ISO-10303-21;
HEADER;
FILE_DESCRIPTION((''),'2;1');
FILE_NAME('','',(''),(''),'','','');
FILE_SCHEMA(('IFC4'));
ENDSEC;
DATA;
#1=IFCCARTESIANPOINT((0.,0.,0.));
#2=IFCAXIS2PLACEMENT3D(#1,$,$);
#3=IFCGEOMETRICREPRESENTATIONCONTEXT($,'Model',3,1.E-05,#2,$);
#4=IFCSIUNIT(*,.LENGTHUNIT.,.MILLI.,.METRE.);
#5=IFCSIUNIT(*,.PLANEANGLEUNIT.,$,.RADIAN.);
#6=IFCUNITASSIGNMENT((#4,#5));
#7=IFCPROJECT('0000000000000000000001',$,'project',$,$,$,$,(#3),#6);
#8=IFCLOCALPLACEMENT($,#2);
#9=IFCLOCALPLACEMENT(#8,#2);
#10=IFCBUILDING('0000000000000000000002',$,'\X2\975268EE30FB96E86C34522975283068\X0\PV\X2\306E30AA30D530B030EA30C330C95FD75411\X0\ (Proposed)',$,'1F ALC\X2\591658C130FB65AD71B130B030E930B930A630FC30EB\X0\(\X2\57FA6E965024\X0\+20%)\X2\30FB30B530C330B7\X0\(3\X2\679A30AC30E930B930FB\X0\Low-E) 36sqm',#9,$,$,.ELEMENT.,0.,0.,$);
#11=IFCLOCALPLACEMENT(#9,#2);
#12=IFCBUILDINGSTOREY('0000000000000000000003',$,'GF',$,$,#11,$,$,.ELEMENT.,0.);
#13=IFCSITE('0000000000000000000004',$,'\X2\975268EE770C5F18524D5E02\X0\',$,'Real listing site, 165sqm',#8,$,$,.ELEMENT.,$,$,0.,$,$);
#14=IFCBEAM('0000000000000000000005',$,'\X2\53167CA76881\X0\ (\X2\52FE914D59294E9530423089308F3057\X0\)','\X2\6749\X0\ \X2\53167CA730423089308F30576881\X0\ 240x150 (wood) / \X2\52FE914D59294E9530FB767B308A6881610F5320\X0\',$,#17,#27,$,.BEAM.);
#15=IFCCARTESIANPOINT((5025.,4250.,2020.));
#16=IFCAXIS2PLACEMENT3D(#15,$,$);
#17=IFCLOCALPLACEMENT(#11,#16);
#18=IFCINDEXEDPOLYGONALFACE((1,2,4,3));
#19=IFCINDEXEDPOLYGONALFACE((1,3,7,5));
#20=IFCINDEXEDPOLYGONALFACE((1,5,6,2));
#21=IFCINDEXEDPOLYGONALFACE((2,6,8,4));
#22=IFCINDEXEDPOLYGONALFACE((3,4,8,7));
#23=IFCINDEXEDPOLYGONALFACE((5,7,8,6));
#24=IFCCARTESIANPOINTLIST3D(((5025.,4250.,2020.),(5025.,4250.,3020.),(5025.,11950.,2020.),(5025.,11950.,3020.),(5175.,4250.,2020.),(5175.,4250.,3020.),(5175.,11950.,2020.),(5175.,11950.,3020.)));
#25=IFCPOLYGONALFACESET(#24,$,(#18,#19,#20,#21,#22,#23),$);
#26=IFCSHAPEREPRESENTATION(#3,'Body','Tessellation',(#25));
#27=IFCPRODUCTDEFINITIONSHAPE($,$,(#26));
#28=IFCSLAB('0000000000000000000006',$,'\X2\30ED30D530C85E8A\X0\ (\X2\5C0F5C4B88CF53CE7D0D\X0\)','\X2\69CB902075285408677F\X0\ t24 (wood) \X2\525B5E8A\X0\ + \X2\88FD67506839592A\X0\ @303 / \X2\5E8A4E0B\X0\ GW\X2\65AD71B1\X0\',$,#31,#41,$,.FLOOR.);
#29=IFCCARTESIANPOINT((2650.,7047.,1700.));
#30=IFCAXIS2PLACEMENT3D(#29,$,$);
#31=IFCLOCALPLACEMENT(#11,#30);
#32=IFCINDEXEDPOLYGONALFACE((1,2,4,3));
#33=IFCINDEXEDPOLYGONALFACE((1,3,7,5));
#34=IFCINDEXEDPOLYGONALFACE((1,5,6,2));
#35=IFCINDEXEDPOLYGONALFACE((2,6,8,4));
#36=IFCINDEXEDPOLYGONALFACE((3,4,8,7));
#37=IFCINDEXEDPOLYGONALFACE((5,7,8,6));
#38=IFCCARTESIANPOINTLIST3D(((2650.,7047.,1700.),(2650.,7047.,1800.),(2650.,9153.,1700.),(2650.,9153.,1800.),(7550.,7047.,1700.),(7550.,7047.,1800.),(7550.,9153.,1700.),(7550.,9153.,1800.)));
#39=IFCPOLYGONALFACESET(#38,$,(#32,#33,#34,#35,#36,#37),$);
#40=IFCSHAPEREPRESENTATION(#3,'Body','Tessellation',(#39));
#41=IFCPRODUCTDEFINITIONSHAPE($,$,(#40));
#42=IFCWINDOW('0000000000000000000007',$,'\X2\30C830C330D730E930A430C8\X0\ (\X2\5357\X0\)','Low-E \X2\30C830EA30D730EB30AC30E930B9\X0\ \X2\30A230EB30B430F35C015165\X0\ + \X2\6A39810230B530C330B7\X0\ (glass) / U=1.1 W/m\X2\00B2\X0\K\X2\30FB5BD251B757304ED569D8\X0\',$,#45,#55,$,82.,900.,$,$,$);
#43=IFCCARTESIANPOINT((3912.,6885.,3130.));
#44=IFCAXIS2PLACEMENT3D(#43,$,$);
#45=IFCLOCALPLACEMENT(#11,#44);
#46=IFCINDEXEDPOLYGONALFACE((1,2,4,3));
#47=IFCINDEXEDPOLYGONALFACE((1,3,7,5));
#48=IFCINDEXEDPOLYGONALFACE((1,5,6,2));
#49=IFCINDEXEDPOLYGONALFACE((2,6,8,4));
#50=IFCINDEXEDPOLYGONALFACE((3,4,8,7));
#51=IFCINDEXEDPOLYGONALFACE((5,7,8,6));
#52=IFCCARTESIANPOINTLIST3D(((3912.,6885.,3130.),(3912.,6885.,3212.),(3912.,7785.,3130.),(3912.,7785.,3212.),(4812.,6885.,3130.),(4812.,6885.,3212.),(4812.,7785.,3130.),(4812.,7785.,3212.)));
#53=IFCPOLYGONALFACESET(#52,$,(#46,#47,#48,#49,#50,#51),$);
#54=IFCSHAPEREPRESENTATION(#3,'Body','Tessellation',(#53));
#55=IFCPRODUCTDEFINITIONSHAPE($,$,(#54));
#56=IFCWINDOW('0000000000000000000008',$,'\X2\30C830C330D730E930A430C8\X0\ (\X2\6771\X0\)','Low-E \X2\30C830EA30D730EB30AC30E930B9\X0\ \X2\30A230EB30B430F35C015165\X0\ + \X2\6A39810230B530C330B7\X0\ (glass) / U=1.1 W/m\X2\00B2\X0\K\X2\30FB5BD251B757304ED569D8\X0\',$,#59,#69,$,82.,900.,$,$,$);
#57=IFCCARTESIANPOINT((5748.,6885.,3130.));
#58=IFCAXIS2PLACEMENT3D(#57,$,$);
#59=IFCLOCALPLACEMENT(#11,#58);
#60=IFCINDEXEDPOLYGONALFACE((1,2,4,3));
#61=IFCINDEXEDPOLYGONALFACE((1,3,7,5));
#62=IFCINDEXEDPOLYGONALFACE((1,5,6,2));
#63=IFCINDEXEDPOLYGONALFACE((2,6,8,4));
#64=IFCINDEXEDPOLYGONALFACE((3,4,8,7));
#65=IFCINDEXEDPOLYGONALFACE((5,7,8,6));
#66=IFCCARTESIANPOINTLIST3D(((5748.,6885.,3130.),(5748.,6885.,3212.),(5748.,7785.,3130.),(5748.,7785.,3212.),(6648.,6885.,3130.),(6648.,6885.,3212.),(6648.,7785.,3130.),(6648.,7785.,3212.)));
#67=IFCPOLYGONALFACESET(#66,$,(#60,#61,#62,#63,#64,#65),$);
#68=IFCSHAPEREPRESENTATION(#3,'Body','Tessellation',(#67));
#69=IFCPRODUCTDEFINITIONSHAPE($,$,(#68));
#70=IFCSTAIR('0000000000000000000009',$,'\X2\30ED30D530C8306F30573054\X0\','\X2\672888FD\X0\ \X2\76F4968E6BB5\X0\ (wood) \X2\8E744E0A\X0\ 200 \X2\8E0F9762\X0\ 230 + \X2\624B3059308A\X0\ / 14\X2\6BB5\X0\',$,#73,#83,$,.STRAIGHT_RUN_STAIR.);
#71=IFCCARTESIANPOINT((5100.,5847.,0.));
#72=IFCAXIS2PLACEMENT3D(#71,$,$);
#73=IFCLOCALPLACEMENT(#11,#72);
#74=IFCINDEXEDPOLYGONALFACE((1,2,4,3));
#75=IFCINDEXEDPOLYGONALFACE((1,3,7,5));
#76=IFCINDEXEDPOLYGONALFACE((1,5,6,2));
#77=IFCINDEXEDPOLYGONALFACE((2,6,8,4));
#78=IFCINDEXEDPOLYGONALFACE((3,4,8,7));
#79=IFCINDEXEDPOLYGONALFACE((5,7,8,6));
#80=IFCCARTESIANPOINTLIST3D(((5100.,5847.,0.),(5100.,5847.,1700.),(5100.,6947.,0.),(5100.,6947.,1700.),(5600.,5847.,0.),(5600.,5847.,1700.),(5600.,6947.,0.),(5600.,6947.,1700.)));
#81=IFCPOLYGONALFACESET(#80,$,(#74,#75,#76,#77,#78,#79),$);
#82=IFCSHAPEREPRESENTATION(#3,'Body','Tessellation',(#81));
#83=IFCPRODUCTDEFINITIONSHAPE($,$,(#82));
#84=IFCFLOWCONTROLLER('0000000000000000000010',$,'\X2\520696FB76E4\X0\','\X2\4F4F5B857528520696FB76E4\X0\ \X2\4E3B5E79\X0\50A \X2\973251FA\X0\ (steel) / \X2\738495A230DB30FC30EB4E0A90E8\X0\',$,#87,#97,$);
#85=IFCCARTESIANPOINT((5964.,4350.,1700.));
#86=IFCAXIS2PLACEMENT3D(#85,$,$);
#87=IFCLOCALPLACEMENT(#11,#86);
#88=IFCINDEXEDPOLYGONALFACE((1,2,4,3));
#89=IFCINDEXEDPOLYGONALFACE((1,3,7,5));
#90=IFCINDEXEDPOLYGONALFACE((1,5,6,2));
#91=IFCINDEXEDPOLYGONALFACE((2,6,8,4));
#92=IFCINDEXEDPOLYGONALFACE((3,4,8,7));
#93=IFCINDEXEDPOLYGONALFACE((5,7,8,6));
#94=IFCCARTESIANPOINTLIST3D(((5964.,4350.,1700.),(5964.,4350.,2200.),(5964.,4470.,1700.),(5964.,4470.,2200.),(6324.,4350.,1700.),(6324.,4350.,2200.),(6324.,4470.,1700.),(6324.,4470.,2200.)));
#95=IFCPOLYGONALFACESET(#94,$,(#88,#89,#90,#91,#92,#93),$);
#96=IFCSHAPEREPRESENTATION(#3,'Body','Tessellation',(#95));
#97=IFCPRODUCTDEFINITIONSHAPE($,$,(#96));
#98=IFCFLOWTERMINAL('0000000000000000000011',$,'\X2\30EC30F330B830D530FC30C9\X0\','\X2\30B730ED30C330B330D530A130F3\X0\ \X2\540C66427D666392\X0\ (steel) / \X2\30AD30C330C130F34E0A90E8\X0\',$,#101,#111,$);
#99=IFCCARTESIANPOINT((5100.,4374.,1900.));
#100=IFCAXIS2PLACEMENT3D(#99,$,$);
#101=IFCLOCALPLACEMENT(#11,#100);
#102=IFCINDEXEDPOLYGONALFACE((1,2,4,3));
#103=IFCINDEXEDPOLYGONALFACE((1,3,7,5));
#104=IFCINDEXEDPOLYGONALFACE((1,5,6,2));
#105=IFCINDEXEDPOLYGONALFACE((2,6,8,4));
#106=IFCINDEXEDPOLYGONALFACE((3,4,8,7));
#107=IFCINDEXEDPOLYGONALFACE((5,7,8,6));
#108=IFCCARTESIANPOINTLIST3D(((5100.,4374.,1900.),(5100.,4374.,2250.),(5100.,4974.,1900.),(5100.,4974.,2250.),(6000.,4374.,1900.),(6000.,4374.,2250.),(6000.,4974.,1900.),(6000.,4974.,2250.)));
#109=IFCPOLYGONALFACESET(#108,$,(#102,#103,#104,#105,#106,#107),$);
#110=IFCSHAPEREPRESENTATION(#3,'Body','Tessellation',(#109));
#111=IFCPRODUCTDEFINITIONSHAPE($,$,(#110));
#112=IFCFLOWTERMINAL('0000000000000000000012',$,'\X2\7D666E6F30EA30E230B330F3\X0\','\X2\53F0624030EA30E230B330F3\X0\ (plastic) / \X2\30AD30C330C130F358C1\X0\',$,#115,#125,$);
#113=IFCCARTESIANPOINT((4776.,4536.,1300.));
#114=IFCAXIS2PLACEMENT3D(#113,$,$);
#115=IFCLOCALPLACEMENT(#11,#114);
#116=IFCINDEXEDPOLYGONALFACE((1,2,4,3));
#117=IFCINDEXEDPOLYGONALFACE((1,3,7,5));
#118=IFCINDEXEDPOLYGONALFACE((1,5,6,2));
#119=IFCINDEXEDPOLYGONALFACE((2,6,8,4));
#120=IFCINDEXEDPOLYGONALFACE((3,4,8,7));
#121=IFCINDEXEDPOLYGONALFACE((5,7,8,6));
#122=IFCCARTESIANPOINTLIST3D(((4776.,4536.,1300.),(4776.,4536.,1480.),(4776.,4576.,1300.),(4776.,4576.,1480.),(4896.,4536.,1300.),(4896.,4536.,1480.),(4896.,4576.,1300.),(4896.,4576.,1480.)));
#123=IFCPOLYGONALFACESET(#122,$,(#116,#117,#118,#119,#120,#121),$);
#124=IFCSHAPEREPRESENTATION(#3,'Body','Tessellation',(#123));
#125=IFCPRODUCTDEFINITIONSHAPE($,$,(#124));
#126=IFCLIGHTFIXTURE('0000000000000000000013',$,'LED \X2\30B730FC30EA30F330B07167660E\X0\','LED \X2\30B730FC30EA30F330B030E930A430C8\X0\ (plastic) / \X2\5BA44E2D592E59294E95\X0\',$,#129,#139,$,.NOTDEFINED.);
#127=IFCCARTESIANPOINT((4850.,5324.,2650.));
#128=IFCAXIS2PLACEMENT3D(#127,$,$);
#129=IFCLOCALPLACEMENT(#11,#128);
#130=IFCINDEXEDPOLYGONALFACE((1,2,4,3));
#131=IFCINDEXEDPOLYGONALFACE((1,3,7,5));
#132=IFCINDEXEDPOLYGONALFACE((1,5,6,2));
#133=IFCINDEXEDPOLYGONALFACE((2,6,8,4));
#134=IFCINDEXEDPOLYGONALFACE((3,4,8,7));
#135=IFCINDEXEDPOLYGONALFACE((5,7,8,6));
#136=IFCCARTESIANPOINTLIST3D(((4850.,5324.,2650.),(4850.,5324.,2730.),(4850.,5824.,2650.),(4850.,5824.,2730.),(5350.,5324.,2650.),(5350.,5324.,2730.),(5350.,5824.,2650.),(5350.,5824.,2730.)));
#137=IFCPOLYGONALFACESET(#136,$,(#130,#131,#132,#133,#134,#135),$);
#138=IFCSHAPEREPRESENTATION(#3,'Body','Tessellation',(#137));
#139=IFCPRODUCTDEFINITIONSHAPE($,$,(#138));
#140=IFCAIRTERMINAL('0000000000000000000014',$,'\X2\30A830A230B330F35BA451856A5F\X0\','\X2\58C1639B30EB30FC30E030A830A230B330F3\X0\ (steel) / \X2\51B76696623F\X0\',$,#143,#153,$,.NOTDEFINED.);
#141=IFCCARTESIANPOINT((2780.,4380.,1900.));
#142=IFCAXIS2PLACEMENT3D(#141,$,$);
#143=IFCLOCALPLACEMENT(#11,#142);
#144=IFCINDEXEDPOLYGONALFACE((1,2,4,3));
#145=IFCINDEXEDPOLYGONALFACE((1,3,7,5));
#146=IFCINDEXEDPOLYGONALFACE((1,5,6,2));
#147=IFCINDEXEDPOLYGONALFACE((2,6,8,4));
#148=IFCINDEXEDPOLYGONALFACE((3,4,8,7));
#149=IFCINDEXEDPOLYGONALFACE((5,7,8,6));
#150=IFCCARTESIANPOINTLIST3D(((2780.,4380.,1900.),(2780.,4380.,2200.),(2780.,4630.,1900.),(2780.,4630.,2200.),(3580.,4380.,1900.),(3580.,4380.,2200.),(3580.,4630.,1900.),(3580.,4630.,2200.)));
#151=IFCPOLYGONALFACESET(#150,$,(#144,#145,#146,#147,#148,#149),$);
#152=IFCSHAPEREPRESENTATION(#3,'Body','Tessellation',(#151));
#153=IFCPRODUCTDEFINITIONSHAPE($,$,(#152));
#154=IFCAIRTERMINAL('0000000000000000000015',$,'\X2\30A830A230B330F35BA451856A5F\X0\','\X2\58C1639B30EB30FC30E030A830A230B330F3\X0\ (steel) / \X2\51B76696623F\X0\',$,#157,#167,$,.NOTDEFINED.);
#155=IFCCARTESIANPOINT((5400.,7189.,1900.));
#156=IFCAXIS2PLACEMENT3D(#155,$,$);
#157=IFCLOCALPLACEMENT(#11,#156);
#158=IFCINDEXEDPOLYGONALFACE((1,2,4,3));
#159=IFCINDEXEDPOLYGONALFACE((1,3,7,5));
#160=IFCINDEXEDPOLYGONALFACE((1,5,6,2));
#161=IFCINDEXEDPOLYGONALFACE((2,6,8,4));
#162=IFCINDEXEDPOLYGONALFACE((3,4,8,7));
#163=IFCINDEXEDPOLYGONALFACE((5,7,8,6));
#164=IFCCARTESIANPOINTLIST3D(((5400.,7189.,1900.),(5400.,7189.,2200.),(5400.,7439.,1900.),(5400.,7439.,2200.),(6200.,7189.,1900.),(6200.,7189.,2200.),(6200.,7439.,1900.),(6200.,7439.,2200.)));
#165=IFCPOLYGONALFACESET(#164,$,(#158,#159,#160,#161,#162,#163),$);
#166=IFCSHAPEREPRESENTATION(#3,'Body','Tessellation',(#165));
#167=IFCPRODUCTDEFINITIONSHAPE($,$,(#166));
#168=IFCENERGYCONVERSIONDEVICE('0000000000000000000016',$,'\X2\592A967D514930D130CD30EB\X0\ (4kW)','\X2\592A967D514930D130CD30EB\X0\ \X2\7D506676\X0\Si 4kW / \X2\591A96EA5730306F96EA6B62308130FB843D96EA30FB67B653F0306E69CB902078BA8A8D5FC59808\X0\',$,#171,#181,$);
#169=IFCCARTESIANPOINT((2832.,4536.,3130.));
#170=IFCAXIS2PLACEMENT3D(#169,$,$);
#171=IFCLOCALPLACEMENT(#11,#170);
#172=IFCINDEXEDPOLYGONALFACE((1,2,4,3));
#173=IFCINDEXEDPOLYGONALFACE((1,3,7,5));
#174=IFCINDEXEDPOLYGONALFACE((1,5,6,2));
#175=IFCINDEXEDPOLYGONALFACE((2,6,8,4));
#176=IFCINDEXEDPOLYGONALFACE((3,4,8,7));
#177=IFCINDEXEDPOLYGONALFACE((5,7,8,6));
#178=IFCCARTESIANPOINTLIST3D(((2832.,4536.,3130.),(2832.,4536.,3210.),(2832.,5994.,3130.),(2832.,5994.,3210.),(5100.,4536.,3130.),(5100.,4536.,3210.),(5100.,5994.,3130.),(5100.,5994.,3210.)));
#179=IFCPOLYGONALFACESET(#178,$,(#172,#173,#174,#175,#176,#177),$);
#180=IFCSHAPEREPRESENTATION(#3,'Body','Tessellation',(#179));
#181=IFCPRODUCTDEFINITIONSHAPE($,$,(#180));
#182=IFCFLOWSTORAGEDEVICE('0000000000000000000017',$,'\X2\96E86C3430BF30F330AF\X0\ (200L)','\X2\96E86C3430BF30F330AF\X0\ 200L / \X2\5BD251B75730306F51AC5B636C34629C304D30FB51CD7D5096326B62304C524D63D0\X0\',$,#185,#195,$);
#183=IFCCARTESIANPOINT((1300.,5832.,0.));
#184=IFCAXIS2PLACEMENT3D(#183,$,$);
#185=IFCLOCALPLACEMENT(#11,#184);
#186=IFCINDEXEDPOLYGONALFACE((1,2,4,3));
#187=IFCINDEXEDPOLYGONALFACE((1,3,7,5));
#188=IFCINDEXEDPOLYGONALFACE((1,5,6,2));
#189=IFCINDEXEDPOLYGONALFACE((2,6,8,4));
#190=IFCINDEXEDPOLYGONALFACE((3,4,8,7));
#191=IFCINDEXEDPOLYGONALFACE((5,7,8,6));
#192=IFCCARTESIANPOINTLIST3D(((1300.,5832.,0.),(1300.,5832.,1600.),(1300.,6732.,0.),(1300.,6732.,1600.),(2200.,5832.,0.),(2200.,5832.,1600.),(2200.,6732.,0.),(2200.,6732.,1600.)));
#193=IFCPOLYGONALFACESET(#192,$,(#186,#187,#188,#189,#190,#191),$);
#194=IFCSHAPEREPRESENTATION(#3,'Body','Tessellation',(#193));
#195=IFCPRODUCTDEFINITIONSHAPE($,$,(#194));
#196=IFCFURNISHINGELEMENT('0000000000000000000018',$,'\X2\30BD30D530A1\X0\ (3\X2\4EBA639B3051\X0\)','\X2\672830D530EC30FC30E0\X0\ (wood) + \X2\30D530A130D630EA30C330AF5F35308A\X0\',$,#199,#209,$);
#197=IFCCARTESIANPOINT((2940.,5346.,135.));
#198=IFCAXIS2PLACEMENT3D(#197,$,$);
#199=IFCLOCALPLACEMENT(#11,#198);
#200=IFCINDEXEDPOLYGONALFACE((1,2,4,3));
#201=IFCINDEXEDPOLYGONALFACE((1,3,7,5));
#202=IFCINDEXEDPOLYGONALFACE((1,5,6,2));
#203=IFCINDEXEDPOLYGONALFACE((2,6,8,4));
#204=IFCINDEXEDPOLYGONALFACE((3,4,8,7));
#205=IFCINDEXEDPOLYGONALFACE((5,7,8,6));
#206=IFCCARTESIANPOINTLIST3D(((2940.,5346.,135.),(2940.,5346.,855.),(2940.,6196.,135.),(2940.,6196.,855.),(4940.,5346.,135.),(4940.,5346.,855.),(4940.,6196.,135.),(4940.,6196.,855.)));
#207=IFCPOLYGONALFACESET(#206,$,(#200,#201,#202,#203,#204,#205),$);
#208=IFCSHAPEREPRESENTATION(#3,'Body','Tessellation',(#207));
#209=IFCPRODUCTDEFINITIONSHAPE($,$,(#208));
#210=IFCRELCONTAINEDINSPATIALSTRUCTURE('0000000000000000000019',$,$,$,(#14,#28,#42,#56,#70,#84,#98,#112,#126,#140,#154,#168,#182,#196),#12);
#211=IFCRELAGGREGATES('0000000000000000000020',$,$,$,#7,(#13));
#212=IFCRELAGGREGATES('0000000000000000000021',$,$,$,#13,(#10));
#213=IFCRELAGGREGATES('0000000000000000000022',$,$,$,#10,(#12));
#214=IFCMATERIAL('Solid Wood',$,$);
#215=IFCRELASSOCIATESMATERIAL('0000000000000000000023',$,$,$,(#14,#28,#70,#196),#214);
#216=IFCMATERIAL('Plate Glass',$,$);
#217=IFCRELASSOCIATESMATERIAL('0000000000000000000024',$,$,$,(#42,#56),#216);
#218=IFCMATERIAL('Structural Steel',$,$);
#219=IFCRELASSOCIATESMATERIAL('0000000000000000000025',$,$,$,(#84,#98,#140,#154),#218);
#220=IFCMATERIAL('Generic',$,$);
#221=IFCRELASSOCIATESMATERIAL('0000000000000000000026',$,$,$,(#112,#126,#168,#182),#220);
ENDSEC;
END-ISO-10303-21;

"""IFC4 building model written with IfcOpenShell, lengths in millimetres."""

from ifc_helpers import new_model, si_unit, frame, frame_2d, origin, place, context, project, spatial, rectangle, extrude, material, element, save


model = new_model("IFC4")

# Units and contexts
model_context = context("Model", 3, precision=1e-05, world=origin())
ifc_project = project(units=[si_unit("LENGTHUNIT", "METRE", prefix="MILLI"), si_unit("PLANEANGLEUNIT", "RADIAN")], contexts=[model_context])

# Site, building, storey
site_placement = place(None, origin())
site = spatial("IfcSite", under=ifc_project, at=site_placement, Name="青森県弘前市", ObjectType="Real listing site, 165sqm", CompositionType="ELEMENT", RefElevation=0.0)
building_placement = place(site_placement, origin())
building = spatial("IfcBuilding", under=site, at=building_placement, Name="青森・雨水利用とPVのオフグリッド志向 (Proposed)", ObjectType="1F ALC外壁・断熱グラスウール(基準値+20%)・サッシ(3枚ガラス・Low-E) 36sqm", CompositionType="ELEMENT", ElevationOfRefHeight=0.0, ElevationOfTerrain=0.0)
storey_placement = place(building_placement, origin())
storey = spatial("IfcBuildingStorey", under=building, at=storey_placement, Name="GF", CompositionType="ELEMENT", Elevation=0.0)

# Shared definitions
ifc_material_1 = material(Name="Solid Wood")

# Beam
beam_placement = place(storey_placement, frame((5025.0, 4250.0, 2020.0)))
element("IfcBeam", 1, at=beam_placement, inside=storey, material=ifc_material_1, Name="化粧梁 (勾配天井あらわし)", Description="杉 化粧あらわし梁 240x150 (wood) / 勾配天井・登り梁意匠", PredefinedType="BEAM", context=model_context, shape_type="SweptSolid", body=[
    extrude(rectangle(XDim=150.0, YDim=7700.0, at=frame_2d((75.0, 3850.0))), frame((5025.0, 4250.0, 2020.0)), (0.0, 0.0, 1.0), 1000.0),
])

# Slab
slab_placement = place(storey_placement, frame((2650.0, 7047.0, 1700.0)))
element("IfcSlab", 2, at=slab_placement, inside=storey, material=ifc_material_1, Name="ロフト床 (小屋裏収納)", Description="構造用合板 t24 (wood) 剛床 + 製材根太 @303 / 床下 GW断熱", PredefinedType="FLOOR", context=model_context, shape_type="SweptSolid", body=[
    extrude(rectangle(XDim=4900.0, YDim=2106.0, at=frame_2d((2450.0, 1053.0))), frame((2650.0, 7047.0, 1700.0)), (0.0, 0.0, 1.0), 100.0),
])

# Windows
ifc_material_2 = material(Name="Plate Glass")
window_1_placement = place(storey_placement, frame((3912.0, 6885.0, 3130.0)))
element("IfcWindow", 3, at=window_1_placement, inside=storey, material=ifc_material_2, Name="トップライト (南)", Description="Low-E トリプルガラス アルゴン封入 + 樹脂サッシ (glass) / U=1.1 W/m²K・寒冷地仕様", OverallHeight=82.0, OverallWidth=900.0, context=model_context, shape_type="SweptSolid", body=[
    extrude(rectangle(XDim=900.0, YDim=900.0, at=frame_2d((450.0, 450.0))), frame((3912.0, 6885.0, 3130.0)), (0.0, 0.0, 1.0), 82.0),
])
window_2_placement = place(storey_placement, frame((5748.0, 6885.0, 3130.0)))
element("IfcWindow", 4, at=window_2_placement, inside=storey, material=ifc_material_2, Name="トップライト (東)", Description="Low-E トリプルガラス アルゴン封入 + 樹脂サッシ (glass) / U=1.1 W/m²K・寒冷地仕様", OverallHeight=82.0, OverallWidth=900.0, context=model_context, shape_type="SweptSolid", body=[
    extrude(rectangle(XDim=900.0, YDim=900.0, at=frame_2d((450.0, 450.0))), frame((5748.0, 6885.0, 3130.0)), (0.0, 0.0, 1.0), 82.0),
])

# Stair
stair_placement = place(storey_placement, frame((5100.0, 5847.0, 0.0)))
element("IfcStair", 5, at=stair_placement, inside=storey, material=ifc_material_1, Name="ロフトはしご", Description="木製 直階段 (wood) 蹴上 200 踏面 230 + 手すり / 14段", PredefinedType="STRAIGHT_RUN_STAIR", context=model_context, shape_type="SweptSolid", body=[
    extrude(rectangle(XDim=500.0, YDim=1100.0, at=frame_2d((250.0, 550.0))), frame((5100.0, 5847.0, 0.0)), (0.0, 0.0, 1.0), 1700.0),
])

# Flow controller
ifc_material_3 = material(Name="Structural Steel")
flow_controller_placement = place(storey_placement, frame((5964.0, 4350.0, 1700.0)))
element("IfcFlowController", 6, at=flow_controller_placement, inside=storey, material=ifc_material_3, Name="分電盤", Description="住宅用分電盤 主幹50A 露出 (steel) / 玄関ホール上部", context=model_context, shape_type="SweptSolid", body=[
    extrude(rectangle(XDim=360.0, YDim=120.0, at=frame_2d((180.0, 60.0))), frame((5964.0, 4350.0, 1700.0)), (0.0, 0.0, 1.0), 500.0),
])

# Flow terminals
flow_terminal_1_placement = place(storey_placement, frame((5100.0, 4374.0, 1900.0)))
element("IfcFlowTerminal", 7, at=flow_terminal_1_placement, inside=storey, material=ifc_material_3, Name="レンジフード", Description="シロッコファン 同時給排 (steel) / キッチン上部", context=model_context, shape_type="SweptSolid", body=[
    extrude(rectangle(XDim=900.0, YDim=600.0, at=frame_2d((450.0, 300.0))), frame((5100.0, 4374.0, 1900.0)), (0.0, 0.0, 1.0), 350.0),
])
ifc_material_4 = material(Name="Generic")
flow_terminal_2_placement = place(storey_placement, frame((4776.0, 4536.0, 1300.0)))
element("IfcFlowTerminal", 8, at=flow_terminal_2_placement, inside=storey, material=ifc_material_4, Name="給湯リモコン", Description="台所リモコン (plastic) / キッチン壁", context=model_context, shape_type="SweptSolid", body=[
    extrude(rectangle(XDim=120.0, YDim=40.0, at=frame_2d((60.0, 20.0))), frame((4776.0, 4536.0, 1300.0)), (0.0, 0.0, 1.0), 180.0),
])

# Light fixture
light_fixture_placement = place(storey_placement, frame((4850.0, 5324.0, 2650.0)))
element("IfcLightFixture", 9, at=light_fixture_placement, inside=storey, material=ifc_material_4, Name="LED シーリング照明", Description="LED シーリングライト (plastic) / 室中央天井", PredefinedType="NOTDEFINED", context=model_context, shape_type="SweptSolid", body=[
    extrude(rectangle(XDim=500.0, YDim=500.0, at=frame_2d((250.0, 250.0))), frame((4850.0, 5324.0, 2650.0)), (0.0, 0.0, 1.0), 80.0),
])

# Air terminals
air_terminal_1_placement = place(storey_placement, frame((2780.0, 4380.0, 1900.0)))
element("IfcAirTerminal", 10, at=air_terminal_1_placement, inside=storey, material=ifc_material_3, Name="エアコン室内機", Description="壁掛ルームエアコン (steel) / 冷暖房", PredefinedType="NOTDEFINED", context=model_context, shape_type="SweptSolid", body=[
    extrude(rectangle(XDim=800.0, YDim=250.0, at=frame_2d((400.0, 125.0))), frame((2780.0, 4380.0, 1900.0)), (0.0, 0.0, 1.0), 300.0),
])
air_terminal_2_placement = place(storey_placement, frame((5400.0, 7189.0, 1900.0)))
element("IfcAirTerminal", 11, at=air_terminal_2_placement, inside=storey, material=ifc_material_3, Name="エアコン室内機", Description="壁掛ルームエアコン (steel) / 冷暖房", PredefinedType="NOTDEFINED", context=model_context, shape_type="SweptSolid", body=[
    extrude(rectangle(XDim=800.0, YDim=250.0, at=frame_2d((400.0, 125.0))), frame((5400.0, 7189.0, 1900.0)), (0.0, 0.0, 1.0), 300.0),
])

# Energy conversion device
energy_conversion_device_placement = place(storey_placement, frame((2832.0, 4536.0, 3130.0)))
element("IfcEnergyConversionDevice", 12, at=energy_conversion_device_placement, inside=storey, material=ifc_material_4, Name="太陽光パネル (4kW)", Description="太陽光パネル 結晶Si 4kW / 多雪地は雪止め・落雪・架台の構造確認必須", context=model_context, shape_type="SweptSolid", body=[
    extrude(rectangle(XDim=2268.0, YDim=1458.0, at=frame_2d((1134.0, 729.0))), frame((2832.0, 4536.0, 3130.0)), (0.0, 0.0, 1.0), 80.0),
])

# Flow storage device
flow_storage_device_placement = place(storey_placement, frame((1300.0, 5832.0, 0.0)))
element("IfcFlowStorageDevice", 13, at=flow_storage_device_placement, inside=storey, material=ifc_material_4, Name="雨水タンク (200L)", Description="雨水タンク 200L / 寒冷地は冬季水抜き・凍結防止が前提", context=model_context, shape_type="SweptSolid", body=[
    extrude(rectangle(XDim=900.0, YDim=900.0, at=frame_2d((450.0, 450.0))), frame((1300.0, 5832.0, 0.0)), (0.0, 0.0, 1.0), 1600.0),
])

# Furnishing element
furnishing_1_placement = place(storey_placement, frame((2940.0, 5346.0, 135.0)))
element("IfcFurnishingElement", 14, at=furnishing_1_placement, inside=storey, material=ifc_material_1, Name="ソファ (3人掛け)", Description="木フレーム (wood) + ファブリック張り", context=model_context, shape_type="SweptSolid", body=[
    extrude(rectangle(XDim=2000.0, YDim=850.0, at=frame_2d((1000.0, 425.0))), frame((2940.0, 5346.0, 135.0)), (0.0, 0.0, 1.0), 720.0),
])

save(model, "model.ifc")
